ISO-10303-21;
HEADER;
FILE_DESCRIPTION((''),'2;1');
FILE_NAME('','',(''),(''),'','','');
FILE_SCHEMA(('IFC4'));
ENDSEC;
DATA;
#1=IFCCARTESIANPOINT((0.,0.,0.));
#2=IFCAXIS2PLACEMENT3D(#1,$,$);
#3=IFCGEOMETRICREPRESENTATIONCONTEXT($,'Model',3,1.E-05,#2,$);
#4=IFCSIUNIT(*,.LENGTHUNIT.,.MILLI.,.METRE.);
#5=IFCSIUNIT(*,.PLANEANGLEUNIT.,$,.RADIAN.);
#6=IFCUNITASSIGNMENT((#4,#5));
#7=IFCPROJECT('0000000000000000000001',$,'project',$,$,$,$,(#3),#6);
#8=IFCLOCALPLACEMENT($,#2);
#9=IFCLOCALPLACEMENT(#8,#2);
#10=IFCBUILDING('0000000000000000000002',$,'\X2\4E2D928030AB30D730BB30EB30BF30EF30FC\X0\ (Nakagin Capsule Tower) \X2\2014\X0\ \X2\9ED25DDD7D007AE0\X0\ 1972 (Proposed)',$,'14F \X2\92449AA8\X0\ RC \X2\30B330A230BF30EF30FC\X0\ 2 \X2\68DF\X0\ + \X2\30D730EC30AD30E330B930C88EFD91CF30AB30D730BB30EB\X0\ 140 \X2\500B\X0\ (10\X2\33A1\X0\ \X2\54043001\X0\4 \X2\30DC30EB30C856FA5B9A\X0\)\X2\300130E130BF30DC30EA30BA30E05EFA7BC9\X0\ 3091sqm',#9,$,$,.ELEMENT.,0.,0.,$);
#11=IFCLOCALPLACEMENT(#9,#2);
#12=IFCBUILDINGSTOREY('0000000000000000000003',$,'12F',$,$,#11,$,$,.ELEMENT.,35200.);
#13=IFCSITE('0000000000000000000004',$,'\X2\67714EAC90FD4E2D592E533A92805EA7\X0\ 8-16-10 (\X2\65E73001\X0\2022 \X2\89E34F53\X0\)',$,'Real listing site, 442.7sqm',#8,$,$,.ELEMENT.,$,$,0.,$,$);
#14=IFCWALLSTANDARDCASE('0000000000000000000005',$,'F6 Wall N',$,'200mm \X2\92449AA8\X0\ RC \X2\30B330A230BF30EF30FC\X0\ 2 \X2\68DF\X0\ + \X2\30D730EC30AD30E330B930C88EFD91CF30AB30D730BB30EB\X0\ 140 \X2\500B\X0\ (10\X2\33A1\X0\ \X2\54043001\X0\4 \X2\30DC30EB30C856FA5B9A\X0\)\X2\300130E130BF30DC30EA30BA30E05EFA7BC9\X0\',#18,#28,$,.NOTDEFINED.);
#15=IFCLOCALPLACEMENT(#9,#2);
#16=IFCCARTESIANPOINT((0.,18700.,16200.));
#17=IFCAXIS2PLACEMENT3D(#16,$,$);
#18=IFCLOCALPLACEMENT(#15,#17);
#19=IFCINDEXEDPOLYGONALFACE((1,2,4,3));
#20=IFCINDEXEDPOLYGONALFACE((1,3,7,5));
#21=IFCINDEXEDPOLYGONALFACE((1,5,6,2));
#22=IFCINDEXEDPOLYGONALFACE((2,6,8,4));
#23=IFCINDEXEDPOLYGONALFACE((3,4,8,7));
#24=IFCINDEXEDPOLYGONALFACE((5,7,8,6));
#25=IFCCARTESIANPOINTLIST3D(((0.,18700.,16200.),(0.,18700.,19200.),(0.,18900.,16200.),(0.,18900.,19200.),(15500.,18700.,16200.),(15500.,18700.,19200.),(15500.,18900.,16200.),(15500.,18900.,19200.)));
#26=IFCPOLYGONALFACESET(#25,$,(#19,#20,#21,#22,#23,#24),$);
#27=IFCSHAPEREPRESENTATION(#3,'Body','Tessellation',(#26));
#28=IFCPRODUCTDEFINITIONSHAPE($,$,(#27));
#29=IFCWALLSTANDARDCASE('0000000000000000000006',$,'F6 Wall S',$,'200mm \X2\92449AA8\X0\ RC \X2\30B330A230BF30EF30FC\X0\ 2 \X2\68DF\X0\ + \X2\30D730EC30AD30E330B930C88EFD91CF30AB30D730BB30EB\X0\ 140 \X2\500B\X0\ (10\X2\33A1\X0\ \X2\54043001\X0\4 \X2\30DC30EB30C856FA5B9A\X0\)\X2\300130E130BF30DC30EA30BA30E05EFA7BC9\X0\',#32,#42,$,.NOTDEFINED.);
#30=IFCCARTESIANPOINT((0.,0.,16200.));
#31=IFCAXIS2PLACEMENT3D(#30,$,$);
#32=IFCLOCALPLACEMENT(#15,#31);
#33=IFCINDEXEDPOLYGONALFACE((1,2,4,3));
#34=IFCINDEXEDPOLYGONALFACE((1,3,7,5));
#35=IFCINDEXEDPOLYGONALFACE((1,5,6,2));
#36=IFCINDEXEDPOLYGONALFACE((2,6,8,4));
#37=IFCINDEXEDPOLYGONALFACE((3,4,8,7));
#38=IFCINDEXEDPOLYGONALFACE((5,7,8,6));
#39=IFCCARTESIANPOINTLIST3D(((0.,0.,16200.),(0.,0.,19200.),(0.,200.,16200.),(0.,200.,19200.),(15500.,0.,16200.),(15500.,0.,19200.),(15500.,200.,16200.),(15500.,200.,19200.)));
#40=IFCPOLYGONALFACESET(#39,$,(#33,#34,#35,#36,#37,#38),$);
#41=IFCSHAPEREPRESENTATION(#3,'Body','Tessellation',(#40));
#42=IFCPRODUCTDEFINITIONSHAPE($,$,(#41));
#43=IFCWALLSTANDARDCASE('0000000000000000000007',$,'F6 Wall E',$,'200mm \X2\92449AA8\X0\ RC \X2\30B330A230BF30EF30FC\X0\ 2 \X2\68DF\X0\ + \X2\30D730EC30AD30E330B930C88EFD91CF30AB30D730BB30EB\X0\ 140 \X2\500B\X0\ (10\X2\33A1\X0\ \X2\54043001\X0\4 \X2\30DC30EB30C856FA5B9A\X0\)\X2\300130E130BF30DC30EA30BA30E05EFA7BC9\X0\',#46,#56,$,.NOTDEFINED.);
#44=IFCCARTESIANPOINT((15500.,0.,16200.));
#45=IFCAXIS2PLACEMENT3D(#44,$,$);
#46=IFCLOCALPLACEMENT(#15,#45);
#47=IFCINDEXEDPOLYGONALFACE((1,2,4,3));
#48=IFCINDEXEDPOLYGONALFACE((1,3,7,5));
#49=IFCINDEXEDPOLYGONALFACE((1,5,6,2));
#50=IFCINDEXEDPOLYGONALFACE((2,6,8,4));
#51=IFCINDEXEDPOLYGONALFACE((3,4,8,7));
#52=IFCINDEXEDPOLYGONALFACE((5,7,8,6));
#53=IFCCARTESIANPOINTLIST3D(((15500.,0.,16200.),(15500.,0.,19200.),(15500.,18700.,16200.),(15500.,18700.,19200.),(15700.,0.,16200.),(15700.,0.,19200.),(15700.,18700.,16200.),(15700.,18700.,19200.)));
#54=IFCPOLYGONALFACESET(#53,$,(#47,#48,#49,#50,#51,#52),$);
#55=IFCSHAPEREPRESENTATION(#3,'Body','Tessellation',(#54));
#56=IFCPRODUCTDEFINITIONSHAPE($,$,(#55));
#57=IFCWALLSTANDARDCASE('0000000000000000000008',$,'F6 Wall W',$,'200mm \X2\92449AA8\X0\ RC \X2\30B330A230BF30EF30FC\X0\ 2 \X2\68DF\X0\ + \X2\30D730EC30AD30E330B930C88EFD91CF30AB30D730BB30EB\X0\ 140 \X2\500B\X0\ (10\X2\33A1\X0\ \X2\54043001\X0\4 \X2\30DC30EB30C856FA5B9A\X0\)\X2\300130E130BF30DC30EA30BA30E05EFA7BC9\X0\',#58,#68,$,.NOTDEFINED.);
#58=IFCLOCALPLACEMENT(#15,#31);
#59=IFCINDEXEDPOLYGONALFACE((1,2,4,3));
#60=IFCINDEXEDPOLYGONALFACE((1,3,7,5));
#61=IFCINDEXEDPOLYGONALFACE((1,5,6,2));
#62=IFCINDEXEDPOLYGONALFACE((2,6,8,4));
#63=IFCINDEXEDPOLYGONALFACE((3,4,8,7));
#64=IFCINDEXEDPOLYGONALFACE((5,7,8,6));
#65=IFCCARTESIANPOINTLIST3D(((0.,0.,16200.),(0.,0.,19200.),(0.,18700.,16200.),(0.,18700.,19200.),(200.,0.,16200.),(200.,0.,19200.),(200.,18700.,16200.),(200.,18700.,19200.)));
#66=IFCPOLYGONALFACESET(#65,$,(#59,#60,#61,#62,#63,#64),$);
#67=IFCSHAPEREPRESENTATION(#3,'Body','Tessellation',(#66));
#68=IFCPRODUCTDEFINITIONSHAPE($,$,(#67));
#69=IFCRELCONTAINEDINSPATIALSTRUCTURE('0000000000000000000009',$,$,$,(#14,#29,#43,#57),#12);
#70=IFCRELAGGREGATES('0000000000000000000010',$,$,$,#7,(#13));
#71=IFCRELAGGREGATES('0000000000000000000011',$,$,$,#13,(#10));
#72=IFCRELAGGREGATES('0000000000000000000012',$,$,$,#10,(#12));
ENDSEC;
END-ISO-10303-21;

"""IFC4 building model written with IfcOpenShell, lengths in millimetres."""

from ifc_helpers import new_model, si_unit, frame, frame_2d, origin, place, context, project, spatial, rectangle, extrude, element, save


model = new_model("IFC4")

# Units and contexts
model_context = context("Model", 3, precision=1e-05, world=origin())
ifc_project = project(units=[si_unit("LENGTHUNIT", "METRE", prefix="MILLI"), si_unit("PLANEANGLEUNIT", "RADIAN")], contexts=[model_context])

# Site, building, storey
site_placement = place(None, origin())
site = spatial("IfcSite", under=ifc_project, at=site_placement, Name="東京都中央区銀座 8-16-10 (旧、2022 解体)", ObjectType="Real listing site, 442.7sqm", CompositionType="ELEMENT", RefElevation=0.0)
building_placement = place(site_placement, origin())
building = spatial("IfcBuilding", under=site, at=building_placement, Name="中銀カプセルタワー (Nakagin Capsule Tower) — 黒川紀章 1972 (Proposed)", ObjectType="14F 鉄骨 RC コアタワー 2 棟 + プレキャスト軽量カプセル 140 個 (10㎡ 各、4 ボルト固定)、メタボリズム建築 3091sqm", CompositionType="ELEMENT", ElevationOfRefHeight=0.0, ElevationOfTerrain=0.0)
storey_placement = place(building_placement, origin())
storey = spatial("IfcBuildingStorey", under=building, at=storey_placement, Name="12F", CompositionType="ELEMENT", Elevation=35200.0)

# Walls
placement = place(building_placement, origin())
wall_1_placement = place(placement, frame((0.0, 18700.0, 16200.0)))
element("IfcWallStandardCase", 1, at=wall_1_placement, inside=storey, Name="F6 Wall N", ObjectType="200mm 鉄骨 RC コアタワー 2 棟 + プレキャスト軽量カプセル 140 個 (10㎡ 各、4 ボルト固定)、メタボリズム建築", PredefinedType="NOTDEFINED", context=model_context, shape_type="SweptSolid", body=[
    extrude(rectangle(XDim=15500.0, YDim=200.0, at=frame_2d((7750.0, 100.0))), frame((0.0, 18700.0, 16200.0)), (0.0, 0.0, 1.0), 3000.0),
])
wall_2_placement = place(placement, frame((0.0, 0.0, 16200.0)))
element("IfcWallStandardCase", 2, at=wall_2_placement, inside=storey, Name="F6 Wall S", ObjectType="200mm 鉄骨 RC コアタワー 2 棟 + プレキャスト軽量カプセル 140 個 (10㎡ 各、4 ボルト固定)、メタボリズム建築", PredefinedType="NOTDEFINED", context=model_context, shape_type="SweptSolid", body=[
    extrude(rectangle(XDim=15500.0, YDim=200.0, at=frame_2d((7750.0, 100.0))), frame((0.0, 0.0, 16200.0)), (0.0, 0.0, 1.0), 3000.0),
])
wall_3_placement = place(placement, frame((15500.0, 0.0, 16200.0)))
element("IfcWallStandardCase", 3, at=wall_3_placement, inside=storey, Name="F6 Wall E", ObjectType="200mm 鉄骨 RC コアタワー 2 棟 + プレキャスト軽量カプセル 140 個 (10㎡ 各、4 ボルト固定)、メタボリズム建築", PredefinedType="NOTDEFINED", context=model_context, shape_type="SweptSolid", body=[
    extrude(rectangle(XDim=200.0, YDim=18700.0, at=frame_2d((100.0, 9350.0))), frame((15500.0, 0.0, 16200.0)), (0.0, 0.0, 1.0), 3000.0),
])
wall_4_placement = place(placement, frame((0.0, 0.0, 16200.0)))
element("IfcWallStandardCase", 4, at=wall_4_placement, inside=storey, Name="F6 Wall W", ObjectType="200mm 鉄骨 RC コアタワー 2 棟 + プレキャスト軽量カプセル 140 個 (10㎡ 各、4 ボルト固定)、メタボリズム建築", PredefinedType="NOTDEFINED", context=model_context, shape_type="SweptSolid", body=[
    extrude(rectangle(XDim=200.0, YDim=18700.0, at=frame_2d((100.0, 9350.0))), frame((0.0, 0.0, 16200.0)), (0.0, 0.0, 1.0), 3000.0),
])

save(model, "model.ifc")
